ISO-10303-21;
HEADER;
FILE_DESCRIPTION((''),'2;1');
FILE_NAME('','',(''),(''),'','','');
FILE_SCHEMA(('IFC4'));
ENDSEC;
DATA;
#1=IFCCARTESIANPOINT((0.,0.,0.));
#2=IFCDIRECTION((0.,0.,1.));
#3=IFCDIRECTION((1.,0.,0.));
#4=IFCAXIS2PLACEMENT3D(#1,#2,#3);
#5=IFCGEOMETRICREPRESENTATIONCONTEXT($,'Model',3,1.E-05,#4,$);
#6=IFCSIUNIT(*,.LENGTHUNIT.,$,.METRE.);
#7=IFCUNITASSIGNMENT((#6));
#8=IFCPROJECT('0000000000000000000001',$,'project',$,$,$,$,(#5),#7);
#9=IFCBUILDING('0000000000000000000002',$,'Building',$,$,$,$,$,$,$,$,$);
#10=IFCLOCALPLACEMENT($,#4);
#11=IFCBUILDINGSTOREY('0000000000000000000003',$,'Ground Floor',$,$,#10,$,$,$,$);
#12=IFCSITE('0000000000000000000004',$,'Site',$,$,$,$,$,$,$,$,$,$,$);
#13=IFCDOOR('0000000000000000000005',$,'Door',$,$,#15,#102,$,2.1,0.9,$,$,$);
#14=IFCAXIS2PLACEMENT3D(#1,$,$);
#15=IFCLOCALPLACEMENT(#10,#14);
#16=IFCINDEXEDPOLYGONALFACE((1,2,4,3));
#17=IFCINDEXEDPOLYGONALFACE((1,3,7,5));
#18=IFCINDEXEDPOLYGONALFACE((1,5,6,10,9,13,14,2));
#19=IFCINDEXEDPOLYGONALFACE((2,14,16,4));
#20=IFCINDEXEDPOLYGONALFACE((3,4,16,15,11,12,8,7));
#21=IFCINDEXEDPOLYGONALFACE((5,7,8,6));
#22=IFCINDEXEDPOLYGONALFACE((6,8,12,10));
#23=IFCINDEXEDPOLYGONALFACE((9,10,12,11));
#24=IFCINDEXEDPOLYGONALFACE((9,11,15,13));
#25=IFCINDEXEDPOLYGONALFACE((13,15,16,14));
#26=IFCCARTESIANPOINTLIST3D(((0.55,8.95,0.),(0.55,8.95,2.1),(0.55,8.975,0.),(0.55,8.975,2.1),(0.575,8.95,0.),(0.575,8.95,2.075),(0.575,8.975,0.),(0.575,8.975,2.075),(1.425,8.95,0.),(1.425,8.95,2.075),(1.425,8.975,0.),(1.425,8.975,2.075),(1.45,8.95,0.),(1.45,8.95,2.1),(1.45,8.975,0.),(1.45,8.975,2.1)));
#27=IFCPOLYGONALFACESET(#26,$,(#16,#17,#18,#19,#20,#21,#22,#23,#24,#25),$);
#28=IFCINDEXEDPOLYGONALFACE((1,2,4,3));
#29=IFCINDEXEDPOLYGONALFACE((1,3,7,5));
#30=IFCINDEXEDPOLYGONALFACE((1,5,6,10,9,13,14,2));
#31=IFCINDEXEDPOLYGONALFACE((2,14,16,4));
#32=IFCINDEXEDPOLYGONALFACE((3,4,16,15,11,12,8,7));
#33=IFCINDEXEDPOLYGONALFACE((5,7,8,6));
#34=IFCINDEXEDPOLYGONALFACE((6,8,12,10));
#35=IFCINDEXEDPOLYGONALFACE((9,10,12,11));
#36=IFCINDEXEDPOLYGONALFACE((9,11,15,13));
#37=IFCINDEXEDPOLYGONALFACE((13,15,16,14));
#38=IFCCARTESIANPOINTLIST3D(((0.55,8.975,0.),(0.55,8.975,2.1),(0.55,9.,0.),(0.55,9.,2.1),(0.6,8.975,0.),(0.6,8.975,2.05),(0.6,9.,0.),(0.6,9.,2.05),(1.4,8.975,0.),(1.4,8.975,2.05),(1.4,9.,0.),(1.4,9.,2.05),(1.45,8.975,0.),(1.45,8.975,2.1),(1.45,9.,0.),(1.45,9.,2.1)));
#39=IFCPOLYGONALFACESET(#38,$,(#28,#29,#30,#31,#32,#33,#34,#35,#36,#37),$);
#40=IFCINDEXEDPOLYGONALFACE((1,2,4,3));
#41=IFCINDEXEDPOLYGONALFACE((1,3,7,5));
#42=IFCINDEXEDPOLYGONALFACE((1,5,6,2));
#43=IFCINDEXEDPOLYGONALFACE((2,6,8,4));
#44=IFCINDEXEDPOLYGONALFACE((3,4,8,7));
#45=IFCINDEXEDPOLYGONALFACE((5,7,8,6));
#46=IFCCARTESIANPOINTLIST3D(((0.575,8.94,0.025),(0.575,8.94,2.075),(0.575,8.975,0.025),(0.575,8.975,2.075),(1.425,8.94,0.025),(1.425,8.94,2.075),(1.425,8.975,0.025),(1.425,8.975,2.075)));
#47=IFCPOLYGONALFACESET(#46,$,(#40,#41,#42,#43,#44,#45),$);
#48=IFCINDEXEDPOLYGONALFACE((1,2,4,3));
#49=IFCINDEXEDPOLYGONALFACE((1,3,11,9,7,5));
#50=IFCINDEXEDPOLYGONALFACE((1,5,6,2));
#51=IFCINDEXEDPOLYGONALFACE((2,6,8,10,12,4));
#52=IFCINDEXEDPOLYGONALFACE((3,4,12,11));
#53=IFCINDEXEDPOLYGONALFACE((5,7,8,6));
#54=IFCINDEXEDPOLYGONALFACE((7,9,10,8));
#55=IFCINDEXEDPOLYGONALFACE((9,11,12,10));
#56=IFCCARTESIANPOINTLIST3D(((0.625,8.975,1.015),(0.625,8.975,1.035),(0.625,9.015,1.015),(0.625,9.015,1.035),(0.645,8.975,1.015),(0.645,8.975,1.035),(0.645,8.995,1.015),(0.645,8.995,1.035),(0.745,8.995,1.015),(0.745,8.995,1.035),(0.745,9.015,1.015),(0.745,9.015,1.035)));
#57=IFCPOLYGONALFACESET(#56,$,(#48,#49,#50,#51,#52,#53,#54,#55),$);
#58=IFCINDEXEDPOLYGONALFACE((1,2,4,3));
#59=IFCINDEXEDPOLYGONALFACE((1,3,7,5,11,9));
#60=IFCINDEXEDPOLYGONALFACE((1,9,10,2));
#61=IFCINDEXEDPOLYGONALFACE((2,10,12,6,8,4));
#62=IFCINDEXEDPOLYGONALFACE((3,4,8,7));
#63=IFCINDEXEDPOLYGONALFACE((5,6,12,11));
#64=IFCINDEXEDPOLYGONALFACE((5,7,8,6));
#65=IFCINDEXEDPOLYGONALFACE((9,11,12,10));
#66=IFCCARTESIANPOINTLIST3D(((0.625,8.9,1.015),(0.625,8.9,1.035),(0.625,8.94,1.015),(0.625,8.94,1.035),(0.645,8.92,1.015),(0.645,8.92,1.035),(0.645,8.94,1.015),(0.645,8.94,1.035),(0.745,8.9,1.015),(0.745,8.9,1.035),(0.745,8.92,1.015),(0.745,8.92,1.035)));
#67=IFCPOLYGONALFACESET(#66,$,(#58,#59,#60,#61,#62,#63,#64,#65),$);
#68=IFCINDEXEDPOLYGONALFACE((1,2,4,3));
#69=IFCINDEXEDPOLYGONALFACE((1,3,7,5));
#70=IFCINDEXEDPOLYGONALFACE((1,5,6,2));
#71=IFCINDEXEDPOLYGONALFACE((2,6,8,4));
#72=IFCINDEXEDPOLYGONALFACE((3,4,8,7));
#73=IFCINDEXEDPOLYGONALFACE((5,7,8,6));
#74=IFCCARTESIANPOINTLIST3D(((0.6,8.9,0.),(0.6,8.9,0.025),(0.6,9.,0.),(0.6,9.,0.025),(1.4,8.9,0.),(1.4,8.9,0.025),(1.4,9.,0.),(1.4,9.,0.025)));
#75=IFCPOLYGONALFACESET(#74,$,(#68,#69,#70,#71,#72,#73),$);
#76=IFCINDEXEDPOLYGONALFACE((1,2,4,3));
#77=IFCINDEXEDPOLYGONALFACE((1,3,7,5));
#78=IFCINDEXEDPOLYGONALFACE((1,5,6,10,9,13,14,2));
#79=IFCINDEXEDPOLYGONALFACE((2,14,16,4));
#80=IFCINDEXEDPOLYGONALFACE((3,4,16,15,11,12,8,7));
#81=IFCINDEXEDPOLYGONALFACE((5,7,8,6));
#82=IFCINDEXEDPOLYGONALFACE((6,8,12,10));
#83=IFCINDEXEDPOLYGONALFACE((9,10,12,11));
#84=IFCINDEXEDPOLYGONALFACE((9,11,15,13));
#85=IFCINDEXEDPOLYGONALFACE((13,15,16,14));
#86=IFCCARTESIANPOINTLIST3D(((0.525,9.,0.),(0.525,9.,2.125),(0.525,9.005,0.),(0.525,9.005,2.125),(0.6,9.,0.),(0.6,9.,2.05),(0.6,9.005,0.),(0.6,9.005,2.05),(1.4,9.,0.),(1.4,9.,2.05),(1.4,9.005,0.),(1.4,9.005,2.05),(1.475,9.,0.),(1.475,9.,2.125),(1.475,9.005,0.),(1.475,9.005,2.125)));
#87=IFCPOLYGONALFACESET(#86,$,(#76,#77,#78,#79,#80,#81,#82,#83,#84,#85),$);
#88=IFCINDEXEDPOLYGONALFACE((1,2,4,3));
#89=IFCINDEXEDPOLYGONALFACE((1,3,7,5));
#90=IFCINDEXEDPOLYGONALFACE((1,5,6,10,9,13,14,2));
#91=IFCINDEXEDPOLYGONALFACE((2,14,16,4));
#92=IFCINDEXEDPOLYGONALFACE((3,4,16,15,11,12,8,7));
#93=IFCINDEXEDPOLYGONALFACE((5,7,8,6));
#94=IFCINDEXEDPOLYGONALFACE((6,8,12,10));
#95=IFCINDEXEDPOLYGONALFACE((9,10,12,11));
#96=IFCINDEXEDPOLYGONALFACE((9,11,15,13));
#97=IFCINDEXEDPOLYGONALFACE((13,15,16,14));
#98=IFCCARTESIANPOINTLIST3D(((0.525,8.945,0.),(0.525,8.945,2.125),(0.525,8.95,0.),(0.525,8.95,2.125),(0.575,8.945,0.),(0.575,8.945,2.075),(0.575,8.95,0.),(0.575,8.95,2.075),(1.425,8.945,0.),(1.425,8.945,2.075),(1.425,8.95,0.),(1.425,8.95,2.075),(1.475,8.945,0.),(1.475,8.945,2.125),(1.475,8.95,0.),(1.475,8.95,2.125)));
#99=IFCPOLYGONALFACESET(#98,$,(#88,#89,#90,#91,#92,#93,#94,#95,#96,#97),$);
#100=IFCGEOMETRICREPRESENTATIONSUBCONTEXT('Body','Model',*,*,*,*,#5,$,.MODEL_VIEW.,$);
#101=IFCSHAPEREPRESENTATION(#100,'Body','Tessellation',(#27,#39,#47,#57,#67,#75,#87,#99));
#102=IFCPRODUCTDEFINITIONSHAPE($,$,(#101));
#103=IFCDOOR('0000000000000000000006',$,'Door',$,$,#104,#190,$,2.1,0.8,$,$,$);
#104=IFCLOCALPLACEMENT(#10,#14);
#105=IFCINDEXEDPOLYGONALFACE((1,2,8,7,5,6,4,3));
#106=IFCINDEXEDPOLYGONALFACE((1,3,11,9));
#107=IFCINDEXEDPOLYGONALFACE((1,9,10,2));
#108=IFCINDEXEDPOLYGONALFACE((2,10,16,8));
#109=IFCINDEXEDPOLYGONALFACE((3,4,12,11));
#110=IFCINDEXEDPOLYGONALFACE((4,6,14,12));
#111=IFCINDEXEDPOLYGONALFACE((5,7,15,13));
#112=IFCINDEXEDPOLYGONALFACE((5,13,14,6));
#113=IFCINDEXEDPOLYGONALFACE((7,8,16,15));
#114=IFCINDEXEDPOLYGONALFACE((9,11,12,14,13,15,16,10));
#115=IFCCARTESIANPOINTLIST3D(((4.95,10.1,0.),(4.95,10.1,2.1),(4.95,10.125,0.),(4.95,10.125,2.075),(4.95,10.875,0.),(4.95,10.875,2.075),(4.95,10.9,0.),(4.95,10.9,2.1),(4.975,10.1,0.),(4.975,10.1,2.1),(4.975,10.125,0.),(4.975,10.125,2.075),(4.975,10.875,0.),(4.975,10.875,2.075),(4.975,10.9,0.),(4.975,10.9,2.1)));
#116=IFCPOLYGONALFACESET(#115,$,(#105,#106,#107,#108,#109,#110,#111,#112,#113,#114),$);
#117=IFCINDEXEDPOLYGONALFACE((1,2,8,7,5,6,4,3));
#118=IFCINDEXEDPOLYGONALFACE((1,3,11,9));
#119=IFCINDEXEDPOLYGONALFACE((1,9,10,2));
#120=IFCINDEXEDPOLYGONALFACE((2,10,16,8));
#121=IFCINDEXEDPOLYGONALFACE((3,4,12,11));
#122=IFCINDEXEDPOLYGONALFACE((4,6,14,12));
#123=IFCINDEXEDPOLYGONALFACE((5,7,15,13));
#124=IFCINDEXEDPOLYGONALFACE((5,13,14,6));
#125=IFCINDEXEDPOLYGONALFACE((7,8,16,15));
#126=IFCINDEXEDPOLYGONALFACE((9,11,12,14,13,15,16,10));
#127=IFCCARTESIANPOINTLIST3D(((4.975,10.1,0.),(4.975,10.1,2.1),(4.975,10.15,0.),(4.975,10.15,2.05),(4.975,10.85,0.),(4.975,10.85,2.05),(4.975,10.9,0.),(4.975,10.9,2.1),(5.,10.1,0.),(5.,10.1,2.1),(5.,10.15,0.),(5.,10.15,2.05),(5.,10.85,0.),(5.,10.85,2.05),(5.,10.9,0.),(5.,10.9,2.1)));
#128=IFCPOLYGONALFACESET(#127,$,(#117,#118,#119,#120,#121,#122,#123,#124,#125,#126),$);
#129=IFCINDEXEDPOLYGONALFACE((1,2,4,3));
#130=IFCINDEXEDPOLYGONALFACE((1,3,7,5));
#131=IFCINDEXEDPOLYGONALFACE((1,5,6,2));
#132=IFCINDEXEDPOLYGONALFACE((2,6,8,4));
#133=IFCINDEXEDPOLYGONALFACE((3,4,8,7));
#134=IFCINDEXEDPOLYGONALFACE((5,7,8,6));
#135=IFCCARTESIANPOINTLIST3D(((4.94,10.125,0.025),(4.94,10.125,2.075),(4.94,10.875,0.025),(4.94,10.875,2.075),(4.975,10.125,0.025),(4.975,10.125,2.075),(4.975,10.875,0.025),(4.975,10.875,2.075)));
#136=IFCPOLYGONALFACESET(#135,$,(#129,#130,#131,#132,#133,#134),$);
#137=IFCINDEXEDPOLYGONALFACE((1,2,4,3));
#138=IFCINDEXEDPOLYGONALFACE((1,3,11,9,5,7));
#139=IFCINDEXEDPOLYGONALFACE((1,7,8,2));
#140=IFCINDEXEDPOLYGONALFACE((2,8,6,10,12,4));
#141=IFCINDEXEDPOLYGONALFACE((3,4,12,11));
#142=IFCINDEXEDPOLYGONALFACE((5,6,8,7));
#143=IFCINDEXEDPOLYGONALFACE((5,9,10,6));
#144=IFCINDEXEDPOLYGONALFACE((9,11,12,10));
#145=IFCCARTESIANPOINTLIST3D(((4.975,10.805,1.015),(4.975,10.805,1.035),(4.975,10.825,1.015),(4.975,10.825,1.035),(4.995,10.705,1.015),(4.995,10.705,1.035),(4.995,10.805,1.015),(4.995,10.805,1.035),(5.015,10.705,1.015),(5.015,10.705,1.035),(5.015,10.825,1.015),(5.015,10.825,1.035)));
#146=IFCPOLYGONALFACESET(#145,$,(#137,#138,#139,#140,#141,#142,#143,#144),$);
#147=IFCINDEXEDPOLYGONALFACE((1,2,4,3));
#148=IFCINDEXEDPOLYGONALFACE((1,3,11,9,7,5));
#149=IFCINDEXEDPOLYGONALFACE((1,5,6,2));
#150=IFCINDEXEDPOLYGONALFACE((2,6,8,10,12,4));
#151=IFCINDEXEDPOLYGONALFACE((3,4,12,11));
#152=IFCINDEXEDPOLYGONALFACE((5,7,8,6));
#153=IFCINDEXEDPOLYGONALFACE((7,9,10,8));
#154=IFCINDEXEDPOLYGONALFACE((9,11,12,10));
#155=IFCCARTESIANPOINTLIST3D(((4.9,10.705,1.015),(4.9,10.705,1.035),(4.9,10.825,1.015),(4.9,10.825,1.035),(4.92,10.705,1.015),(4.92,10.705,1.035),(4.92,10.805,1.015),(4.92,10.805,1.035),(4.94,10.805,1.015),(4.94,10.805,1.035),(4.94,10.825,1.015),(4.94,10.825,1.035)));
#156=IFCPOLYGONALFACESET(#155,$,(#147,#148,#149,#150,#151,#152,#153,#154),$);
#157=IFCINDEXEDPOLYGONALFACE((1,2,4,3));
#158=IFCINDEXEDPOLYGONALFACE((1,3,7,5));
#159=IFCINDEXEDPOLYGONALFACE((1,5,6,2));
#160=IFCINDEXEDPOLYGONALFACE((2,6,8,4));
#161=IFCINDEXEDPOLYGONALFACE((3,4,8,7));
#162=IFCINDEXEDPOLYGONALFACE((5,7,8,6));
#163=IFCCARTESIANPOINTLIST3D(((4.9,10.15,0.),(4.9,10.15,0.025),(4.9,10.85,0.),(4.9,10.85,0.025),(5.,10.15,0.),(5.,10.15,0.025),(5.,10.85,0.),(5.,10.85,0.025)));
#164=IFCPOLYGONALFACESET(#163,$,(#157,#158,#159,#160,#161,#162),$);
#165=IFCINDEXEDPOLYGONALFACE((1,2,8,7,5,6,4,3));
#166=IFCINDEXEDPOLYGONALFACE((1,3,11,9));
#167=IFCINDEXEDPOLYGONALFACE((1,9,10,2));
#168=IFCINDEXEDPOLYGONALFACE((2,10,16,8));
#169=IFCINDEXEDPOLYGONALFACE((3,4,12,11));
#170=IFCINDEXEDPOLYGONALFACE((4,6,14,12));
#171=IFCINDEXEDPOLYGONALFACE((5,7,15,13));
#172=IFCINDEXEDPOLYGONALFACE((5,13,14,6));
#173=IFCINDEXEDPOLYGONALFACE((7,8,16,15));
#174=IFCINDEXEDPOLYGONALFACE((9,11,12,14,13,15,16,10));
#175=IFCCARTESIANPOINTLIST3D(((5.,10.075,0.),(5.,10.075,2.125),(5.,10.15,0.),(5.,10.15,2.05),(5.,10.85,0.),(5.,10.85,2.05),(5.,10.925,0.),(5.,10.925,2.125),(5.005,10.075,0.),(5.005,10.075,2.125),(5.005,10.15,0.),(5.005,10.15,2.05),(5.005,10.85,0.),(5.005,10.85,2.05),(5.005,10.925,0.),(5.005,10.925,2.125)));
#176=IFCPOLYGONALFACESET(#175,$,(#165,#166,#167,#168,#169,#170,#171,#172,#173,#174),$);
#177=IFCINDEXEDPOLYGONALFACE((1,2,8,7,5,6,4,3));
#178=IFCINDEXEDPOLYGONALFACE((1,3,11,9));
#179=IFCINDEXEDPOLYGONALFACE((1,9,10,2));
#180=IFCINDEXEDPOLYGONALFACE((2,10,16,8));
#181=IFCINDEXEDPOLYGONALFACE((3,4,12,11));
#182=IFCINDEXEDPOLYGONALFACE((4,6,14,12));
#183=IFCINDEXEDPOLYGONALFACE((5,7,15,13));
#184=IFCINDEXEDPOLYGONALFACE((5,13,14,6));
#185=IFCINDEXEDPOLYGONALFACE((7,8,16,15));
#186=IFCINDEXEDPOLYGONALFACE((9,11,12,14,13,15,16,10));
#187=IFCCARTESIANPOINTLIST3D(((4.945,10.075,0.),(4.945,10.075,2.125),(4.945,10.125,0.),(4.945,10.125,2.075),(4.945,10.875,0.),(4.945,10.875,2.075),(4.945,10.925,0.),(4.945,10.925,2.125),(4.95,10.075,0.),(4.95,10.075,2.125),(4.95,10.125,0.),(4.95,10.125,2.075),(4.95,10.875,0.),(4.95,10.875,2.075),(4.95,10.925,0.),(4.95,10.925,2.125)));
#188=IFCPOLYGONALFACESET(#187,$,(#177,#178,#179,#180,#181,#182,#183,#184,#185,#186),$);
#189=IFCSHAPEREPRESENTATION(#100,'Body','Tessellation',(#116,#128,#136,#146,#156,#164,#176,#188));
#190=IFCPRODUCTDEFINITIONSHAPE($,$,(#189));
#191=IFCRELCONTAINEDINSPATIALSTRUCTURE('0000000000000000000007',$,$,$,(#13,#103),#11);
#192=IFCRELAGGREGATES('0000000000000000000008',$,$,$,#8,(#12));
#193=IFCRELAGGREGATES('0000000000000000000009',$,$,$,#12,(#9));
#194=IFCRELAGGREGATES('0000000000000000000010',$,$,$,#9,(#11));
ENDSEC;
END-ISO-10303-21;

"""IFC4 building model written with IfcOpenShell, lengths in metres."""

from ifc_helpers import new_model, si_unit, frame, origin_with_axes, place, context, subcontext, project, spatial, line, indexed_curve, outline, extrude, element, save


model = new_model("IFC4")

# Units and contexts
model_context = context("Model", 3, precision=1e-05, world=origin_with_axes())
body_context = subcontext(model_context, "Body", "Model", "MODEL_VIEW")
ifc_project = project(units=[si_unit("LENGTHUNIT", "METRE")], contexts=[model_context])

# Site, building, storey
site = spatial("IfcSite", under=ifc_project, Name="Site")
building = spatial("IfcBuilding", under=site, Name="Building")
storey_placement = place(None, origin_with_axes())
storey = spatial("IfcBuildingStorey", under=building, at=storey_placement, Name="Ground Floor")

# Doors
door_1_placement = place(storey_placement, frame((1.45, 9.0, 0.0), z_axis=(0.0, 0.0, 1.0), x_axis=(-1.0, 0.0, 0.0)))
element("IfcDoor", 1, at=door_1_placement, inside=storey, Name="Door", OverallHeight=2.1, OverallWidth=0.9, context=body_context, shape_type="SweptSolid", body=[
    extrude(outline(indexed_curve([(0.0, 0.0), (0.0, 2.1), (0.9, 2.1), (0.9, 0.0), (0.875, 0.0), (0.875, 2.075), (0.025, 2.075), (0.025, 0.0)], segments=[line(1, 2, 3, 4, 5, 6, 7, 8, 1)])), frame((0.0, 0.025, 0.0), z_axis=(0.0, -1.0, 0.0), x_axis=(1.0, 0.0, 0.0)), (0.0, 0.0, -1.0), 0.025),
    extrude(outline(indexed_curve([(0.0, 0.0), (0.0, 2.1), (0.9, 2.1), (0.9, 0.0), (0.85, 0.0), (0.85, 2.05), (0.05, 2.05), (0.05, 0.0)], segments=[line(1, 2, 3, 4, 5, 6, 7, 8, 1)])), frame((0.0, 0.0, 0.0), z_axis=(0.0, -1.0, 0.0), x_axis=(1.0, 0.0, 0.0)), (0.0, 0.0, -1.0), 0.025),
    extrude(outline(indexed_curve([(0.0, 0.0), (0.85, 0.0), (0.85, 0.035), (0.0, 0.035)], segments=[line(1, 2, 3, 4, 1)])), frame((0.025, 0.025, 0.025), z_axis=(0.0, 0.0, 1.0), x_axis=(1.0, 0.0, 0.0)), (0.0, 0.0, 1.0), 2.05),
    extrude(outline(indexed_curve([(0.0, 0.0), (0.0, -0.04), (-0.12, -0.04), (-0.12, -0.02), (-0.02, -0.02), (-0.02, 0.0)], segments=[line(1, 2, 3, 4, 5, 6, 1)])), frame((0.825, 0.025, 1.015), z_axis=(0.0, 0.0, 1.0), x_axis=(1.0, 0.0, 0.0)), (0.0, 0.0, 1.0), 0.02),
    extrude(outline(indexed_curve([(0.0, 0.0), (0.0, 0.04), (-0.12, 0.04), (-0.12, 0.02), (-0.02, 0.02), (-0.02, 0.0)], segments=[line(1, 2, 3, 4, 5, 6, 1)])), frame((0.825, 0.06, 1.015), z_axis=(0.0, 0.0, 1.0), x_axis=(1.0, 0.0, 0.0)), (0.0, 0.0, 1.0), 0.02),
    extrude(outline(indexed_curve([(0.0, 0.0), (0.8, 0.0), (0.8, 0.1), (0.0, 0.1)], segments=[line(1, 2, 3, 4, 1)])), frame((0.05, 0.0, 0.0), z_axis=(0.0, 0.0, 1.0), x_axis=(1.0, 0.0, 0.0)), (0.0, 0.0, 1.0), 0.025),
    extrude(outline(indexed_curve([(0.0, 0.0), (0.0, 2.125), (0.95, 2.125), (0.95, 0.0), (0.875, 0.0), (0.875, 2.05), (0.075, 2.05), (0.075, 0.0)], segments=[line(1, 2, 3, 4, 5, 6, 7, 8, 1)])), frame((-0.025, -0.005, 0.0), z_axis=(0.0, -1.0, 0.0), x_axis=(1.0, 0.0, 0.0)), (0.0, 0.0, -1.0), 0.005),
    extrude(outline(indexed_curve([(0.0, 0.0), (0.0, 2.125), (0.95, 2.125), (0.95, 0.0), (0.9, 0.0), (0.9, 2.075), (0.05, 2.075), (0.05, 0.0)], segments=[line(1, 2, 3, 4, 5, 6, 7, 8, 1)])), frame((-0.025, 0.05, 0.0), z_axis=(0.0, -1.0, 0.0), x_axis=(1.0, 0.0, 0.0)), (0.0, 0.0, -1.0), 0.005),
])
door_2_placement = place(storey_placement, frame((5.0, 10.1, 0.0), z_axis=(0.0, 0.0, 1.0), x_axis=(0.0, 1.0, 0.0)))
element("IfcDoor", 2, at=door_2_placement, inside=storey, Name="Door", OverallHeight=2.1, OverallWidth=0.8, context=body_context, shape_type="SweptSolid", body=[
    extrude(outline(indexed_curve([(0.0, 0.0), (0.0, 2.1), (0.8, 2.1), (0.8, 0.0), (0.775, 0.0), (0.775, 2.075), (0.025, 2.075), (0.025, 0.0)], segments=[line(1, 2, 3, 4, 5, 6, 7, 8, 1)])), frame((0.0, 0.025, 0.0), z_axis=(0.0, -1.0, 0.0), x_axis=(1.0, 0.0, 0.0)), (0.0, 0.0, -1.0), 0.025),
    extrude(outline(indexed_curve([(0.0, 0.0), (0.0, 2.1), (0.8, 2.1), (0.8, 0.0), (0.75, 0.0), (0.75, 2.05), (0.05, 2.05), (0.05, 0.0)], segments=[line(1, 2, 3, 4, 5, 6, 7, 8, 1)])), frame((0.0, 0.0, 0.0), z_axis=(0.0, -1.0, 0.0), x_axis=(1.0, 0.0, 0.0)), (0.0, 0.0, -1.0), 0.025),
    extrude(outline(indexed_curve([(0.0, 0.0), (0.75, 0.0), (0.75, 0.035), (0.0, 0.035)], segments=[line(1, 2, 3, 4, 1)])), frame((0.025, 0.025, 0.025), z_axis=(0.0, 0.0, 1.0), x_axis=(1.0, 0.0, 0.0)), (0.0, 0.0, 1.0), 2.05),
    extrude(outline(indexed_curve([(0.0, 0.0), (0.0, -0.04), (-0.12, -0.04), (-0.12, -0.02), (-0.02, -0.02), (-0.02, 0.0)], segments=[line(1, 2, 3, 4, 5, 6, 1)])), frame((0.725, 0.025, 1.015), z_axis=(0.0, 0.0, 1.0), x_axis=(1.0, 0.0, 0.0)), (0.0, 0.0, 1.0), 0.02),
    extrude(outline(indexed_curve([(0.0, 0.0), (0.0, 0.04), (-0.12, 0.04), (-0.12, 0.02), (-0.02, 0.02), (-0.02, 0.0)], segments=[line(1, 2, 3, 4, 5, 6, 1)])), frame((0.725, 0.06, 1.015), z_axis=(0.0, 0.0, 1.0), x_axis=(1.0, 0.0, 0.0)), (0.0, 0.0, 1.0), 0.02),
    extrude(outline(indexed_curve([(0.0, 0.0), (0.7, 0.0), (0.7, 0.1), (0.0, 0.1)], segments=[line(1, 2, 3, 4, 1)])), frame((0.05, 0.0, 0.0), z_axis=(0.0, 0.0, 1.0), x_axis=(1.0, 0.0, 0.0)), (0.0, 0.0, 1.0), 0.025),
    extrude(outline(indexed_curve([(0.0, 0.0), (0.0, 2.125), (0.85, 2.125), (0.85, 0.0), (0.775, 0.0), (0.775, 2.05), (0.075, 2.05), (0.075, 0.0)], segments=[line(1, 2, 3, 4, 5, 6, 7, 8, 1)])), frame((-0.025, -0.005, 0.0), z_axis=(0.0, -1.0, 0.0), x_axis=(1.0, 0.0, 0.0)), (0.0, 0.0, -1.0), 0.005),
    extrude(outline(indexed_curve([(0.0, 0.0), (0.0, 2.125), (0.85, 2.125), (0.85, 0.0), (0.8, 0.0), (0.8, 2.075), (0.05, 2.075), (0.05, 0.0)], segments=[line(1, 2, 3, 4, 5, 6, 7, 8, 1)])), frame((-0.025, 0.05, 0.0), z_axis=(0.0, -1.0, 0.0), x_axis=(1.0, 0.0, 0.0)), (0.0, 0.0, -1.0), 0.005),
])

save(model, "model.ifc")
